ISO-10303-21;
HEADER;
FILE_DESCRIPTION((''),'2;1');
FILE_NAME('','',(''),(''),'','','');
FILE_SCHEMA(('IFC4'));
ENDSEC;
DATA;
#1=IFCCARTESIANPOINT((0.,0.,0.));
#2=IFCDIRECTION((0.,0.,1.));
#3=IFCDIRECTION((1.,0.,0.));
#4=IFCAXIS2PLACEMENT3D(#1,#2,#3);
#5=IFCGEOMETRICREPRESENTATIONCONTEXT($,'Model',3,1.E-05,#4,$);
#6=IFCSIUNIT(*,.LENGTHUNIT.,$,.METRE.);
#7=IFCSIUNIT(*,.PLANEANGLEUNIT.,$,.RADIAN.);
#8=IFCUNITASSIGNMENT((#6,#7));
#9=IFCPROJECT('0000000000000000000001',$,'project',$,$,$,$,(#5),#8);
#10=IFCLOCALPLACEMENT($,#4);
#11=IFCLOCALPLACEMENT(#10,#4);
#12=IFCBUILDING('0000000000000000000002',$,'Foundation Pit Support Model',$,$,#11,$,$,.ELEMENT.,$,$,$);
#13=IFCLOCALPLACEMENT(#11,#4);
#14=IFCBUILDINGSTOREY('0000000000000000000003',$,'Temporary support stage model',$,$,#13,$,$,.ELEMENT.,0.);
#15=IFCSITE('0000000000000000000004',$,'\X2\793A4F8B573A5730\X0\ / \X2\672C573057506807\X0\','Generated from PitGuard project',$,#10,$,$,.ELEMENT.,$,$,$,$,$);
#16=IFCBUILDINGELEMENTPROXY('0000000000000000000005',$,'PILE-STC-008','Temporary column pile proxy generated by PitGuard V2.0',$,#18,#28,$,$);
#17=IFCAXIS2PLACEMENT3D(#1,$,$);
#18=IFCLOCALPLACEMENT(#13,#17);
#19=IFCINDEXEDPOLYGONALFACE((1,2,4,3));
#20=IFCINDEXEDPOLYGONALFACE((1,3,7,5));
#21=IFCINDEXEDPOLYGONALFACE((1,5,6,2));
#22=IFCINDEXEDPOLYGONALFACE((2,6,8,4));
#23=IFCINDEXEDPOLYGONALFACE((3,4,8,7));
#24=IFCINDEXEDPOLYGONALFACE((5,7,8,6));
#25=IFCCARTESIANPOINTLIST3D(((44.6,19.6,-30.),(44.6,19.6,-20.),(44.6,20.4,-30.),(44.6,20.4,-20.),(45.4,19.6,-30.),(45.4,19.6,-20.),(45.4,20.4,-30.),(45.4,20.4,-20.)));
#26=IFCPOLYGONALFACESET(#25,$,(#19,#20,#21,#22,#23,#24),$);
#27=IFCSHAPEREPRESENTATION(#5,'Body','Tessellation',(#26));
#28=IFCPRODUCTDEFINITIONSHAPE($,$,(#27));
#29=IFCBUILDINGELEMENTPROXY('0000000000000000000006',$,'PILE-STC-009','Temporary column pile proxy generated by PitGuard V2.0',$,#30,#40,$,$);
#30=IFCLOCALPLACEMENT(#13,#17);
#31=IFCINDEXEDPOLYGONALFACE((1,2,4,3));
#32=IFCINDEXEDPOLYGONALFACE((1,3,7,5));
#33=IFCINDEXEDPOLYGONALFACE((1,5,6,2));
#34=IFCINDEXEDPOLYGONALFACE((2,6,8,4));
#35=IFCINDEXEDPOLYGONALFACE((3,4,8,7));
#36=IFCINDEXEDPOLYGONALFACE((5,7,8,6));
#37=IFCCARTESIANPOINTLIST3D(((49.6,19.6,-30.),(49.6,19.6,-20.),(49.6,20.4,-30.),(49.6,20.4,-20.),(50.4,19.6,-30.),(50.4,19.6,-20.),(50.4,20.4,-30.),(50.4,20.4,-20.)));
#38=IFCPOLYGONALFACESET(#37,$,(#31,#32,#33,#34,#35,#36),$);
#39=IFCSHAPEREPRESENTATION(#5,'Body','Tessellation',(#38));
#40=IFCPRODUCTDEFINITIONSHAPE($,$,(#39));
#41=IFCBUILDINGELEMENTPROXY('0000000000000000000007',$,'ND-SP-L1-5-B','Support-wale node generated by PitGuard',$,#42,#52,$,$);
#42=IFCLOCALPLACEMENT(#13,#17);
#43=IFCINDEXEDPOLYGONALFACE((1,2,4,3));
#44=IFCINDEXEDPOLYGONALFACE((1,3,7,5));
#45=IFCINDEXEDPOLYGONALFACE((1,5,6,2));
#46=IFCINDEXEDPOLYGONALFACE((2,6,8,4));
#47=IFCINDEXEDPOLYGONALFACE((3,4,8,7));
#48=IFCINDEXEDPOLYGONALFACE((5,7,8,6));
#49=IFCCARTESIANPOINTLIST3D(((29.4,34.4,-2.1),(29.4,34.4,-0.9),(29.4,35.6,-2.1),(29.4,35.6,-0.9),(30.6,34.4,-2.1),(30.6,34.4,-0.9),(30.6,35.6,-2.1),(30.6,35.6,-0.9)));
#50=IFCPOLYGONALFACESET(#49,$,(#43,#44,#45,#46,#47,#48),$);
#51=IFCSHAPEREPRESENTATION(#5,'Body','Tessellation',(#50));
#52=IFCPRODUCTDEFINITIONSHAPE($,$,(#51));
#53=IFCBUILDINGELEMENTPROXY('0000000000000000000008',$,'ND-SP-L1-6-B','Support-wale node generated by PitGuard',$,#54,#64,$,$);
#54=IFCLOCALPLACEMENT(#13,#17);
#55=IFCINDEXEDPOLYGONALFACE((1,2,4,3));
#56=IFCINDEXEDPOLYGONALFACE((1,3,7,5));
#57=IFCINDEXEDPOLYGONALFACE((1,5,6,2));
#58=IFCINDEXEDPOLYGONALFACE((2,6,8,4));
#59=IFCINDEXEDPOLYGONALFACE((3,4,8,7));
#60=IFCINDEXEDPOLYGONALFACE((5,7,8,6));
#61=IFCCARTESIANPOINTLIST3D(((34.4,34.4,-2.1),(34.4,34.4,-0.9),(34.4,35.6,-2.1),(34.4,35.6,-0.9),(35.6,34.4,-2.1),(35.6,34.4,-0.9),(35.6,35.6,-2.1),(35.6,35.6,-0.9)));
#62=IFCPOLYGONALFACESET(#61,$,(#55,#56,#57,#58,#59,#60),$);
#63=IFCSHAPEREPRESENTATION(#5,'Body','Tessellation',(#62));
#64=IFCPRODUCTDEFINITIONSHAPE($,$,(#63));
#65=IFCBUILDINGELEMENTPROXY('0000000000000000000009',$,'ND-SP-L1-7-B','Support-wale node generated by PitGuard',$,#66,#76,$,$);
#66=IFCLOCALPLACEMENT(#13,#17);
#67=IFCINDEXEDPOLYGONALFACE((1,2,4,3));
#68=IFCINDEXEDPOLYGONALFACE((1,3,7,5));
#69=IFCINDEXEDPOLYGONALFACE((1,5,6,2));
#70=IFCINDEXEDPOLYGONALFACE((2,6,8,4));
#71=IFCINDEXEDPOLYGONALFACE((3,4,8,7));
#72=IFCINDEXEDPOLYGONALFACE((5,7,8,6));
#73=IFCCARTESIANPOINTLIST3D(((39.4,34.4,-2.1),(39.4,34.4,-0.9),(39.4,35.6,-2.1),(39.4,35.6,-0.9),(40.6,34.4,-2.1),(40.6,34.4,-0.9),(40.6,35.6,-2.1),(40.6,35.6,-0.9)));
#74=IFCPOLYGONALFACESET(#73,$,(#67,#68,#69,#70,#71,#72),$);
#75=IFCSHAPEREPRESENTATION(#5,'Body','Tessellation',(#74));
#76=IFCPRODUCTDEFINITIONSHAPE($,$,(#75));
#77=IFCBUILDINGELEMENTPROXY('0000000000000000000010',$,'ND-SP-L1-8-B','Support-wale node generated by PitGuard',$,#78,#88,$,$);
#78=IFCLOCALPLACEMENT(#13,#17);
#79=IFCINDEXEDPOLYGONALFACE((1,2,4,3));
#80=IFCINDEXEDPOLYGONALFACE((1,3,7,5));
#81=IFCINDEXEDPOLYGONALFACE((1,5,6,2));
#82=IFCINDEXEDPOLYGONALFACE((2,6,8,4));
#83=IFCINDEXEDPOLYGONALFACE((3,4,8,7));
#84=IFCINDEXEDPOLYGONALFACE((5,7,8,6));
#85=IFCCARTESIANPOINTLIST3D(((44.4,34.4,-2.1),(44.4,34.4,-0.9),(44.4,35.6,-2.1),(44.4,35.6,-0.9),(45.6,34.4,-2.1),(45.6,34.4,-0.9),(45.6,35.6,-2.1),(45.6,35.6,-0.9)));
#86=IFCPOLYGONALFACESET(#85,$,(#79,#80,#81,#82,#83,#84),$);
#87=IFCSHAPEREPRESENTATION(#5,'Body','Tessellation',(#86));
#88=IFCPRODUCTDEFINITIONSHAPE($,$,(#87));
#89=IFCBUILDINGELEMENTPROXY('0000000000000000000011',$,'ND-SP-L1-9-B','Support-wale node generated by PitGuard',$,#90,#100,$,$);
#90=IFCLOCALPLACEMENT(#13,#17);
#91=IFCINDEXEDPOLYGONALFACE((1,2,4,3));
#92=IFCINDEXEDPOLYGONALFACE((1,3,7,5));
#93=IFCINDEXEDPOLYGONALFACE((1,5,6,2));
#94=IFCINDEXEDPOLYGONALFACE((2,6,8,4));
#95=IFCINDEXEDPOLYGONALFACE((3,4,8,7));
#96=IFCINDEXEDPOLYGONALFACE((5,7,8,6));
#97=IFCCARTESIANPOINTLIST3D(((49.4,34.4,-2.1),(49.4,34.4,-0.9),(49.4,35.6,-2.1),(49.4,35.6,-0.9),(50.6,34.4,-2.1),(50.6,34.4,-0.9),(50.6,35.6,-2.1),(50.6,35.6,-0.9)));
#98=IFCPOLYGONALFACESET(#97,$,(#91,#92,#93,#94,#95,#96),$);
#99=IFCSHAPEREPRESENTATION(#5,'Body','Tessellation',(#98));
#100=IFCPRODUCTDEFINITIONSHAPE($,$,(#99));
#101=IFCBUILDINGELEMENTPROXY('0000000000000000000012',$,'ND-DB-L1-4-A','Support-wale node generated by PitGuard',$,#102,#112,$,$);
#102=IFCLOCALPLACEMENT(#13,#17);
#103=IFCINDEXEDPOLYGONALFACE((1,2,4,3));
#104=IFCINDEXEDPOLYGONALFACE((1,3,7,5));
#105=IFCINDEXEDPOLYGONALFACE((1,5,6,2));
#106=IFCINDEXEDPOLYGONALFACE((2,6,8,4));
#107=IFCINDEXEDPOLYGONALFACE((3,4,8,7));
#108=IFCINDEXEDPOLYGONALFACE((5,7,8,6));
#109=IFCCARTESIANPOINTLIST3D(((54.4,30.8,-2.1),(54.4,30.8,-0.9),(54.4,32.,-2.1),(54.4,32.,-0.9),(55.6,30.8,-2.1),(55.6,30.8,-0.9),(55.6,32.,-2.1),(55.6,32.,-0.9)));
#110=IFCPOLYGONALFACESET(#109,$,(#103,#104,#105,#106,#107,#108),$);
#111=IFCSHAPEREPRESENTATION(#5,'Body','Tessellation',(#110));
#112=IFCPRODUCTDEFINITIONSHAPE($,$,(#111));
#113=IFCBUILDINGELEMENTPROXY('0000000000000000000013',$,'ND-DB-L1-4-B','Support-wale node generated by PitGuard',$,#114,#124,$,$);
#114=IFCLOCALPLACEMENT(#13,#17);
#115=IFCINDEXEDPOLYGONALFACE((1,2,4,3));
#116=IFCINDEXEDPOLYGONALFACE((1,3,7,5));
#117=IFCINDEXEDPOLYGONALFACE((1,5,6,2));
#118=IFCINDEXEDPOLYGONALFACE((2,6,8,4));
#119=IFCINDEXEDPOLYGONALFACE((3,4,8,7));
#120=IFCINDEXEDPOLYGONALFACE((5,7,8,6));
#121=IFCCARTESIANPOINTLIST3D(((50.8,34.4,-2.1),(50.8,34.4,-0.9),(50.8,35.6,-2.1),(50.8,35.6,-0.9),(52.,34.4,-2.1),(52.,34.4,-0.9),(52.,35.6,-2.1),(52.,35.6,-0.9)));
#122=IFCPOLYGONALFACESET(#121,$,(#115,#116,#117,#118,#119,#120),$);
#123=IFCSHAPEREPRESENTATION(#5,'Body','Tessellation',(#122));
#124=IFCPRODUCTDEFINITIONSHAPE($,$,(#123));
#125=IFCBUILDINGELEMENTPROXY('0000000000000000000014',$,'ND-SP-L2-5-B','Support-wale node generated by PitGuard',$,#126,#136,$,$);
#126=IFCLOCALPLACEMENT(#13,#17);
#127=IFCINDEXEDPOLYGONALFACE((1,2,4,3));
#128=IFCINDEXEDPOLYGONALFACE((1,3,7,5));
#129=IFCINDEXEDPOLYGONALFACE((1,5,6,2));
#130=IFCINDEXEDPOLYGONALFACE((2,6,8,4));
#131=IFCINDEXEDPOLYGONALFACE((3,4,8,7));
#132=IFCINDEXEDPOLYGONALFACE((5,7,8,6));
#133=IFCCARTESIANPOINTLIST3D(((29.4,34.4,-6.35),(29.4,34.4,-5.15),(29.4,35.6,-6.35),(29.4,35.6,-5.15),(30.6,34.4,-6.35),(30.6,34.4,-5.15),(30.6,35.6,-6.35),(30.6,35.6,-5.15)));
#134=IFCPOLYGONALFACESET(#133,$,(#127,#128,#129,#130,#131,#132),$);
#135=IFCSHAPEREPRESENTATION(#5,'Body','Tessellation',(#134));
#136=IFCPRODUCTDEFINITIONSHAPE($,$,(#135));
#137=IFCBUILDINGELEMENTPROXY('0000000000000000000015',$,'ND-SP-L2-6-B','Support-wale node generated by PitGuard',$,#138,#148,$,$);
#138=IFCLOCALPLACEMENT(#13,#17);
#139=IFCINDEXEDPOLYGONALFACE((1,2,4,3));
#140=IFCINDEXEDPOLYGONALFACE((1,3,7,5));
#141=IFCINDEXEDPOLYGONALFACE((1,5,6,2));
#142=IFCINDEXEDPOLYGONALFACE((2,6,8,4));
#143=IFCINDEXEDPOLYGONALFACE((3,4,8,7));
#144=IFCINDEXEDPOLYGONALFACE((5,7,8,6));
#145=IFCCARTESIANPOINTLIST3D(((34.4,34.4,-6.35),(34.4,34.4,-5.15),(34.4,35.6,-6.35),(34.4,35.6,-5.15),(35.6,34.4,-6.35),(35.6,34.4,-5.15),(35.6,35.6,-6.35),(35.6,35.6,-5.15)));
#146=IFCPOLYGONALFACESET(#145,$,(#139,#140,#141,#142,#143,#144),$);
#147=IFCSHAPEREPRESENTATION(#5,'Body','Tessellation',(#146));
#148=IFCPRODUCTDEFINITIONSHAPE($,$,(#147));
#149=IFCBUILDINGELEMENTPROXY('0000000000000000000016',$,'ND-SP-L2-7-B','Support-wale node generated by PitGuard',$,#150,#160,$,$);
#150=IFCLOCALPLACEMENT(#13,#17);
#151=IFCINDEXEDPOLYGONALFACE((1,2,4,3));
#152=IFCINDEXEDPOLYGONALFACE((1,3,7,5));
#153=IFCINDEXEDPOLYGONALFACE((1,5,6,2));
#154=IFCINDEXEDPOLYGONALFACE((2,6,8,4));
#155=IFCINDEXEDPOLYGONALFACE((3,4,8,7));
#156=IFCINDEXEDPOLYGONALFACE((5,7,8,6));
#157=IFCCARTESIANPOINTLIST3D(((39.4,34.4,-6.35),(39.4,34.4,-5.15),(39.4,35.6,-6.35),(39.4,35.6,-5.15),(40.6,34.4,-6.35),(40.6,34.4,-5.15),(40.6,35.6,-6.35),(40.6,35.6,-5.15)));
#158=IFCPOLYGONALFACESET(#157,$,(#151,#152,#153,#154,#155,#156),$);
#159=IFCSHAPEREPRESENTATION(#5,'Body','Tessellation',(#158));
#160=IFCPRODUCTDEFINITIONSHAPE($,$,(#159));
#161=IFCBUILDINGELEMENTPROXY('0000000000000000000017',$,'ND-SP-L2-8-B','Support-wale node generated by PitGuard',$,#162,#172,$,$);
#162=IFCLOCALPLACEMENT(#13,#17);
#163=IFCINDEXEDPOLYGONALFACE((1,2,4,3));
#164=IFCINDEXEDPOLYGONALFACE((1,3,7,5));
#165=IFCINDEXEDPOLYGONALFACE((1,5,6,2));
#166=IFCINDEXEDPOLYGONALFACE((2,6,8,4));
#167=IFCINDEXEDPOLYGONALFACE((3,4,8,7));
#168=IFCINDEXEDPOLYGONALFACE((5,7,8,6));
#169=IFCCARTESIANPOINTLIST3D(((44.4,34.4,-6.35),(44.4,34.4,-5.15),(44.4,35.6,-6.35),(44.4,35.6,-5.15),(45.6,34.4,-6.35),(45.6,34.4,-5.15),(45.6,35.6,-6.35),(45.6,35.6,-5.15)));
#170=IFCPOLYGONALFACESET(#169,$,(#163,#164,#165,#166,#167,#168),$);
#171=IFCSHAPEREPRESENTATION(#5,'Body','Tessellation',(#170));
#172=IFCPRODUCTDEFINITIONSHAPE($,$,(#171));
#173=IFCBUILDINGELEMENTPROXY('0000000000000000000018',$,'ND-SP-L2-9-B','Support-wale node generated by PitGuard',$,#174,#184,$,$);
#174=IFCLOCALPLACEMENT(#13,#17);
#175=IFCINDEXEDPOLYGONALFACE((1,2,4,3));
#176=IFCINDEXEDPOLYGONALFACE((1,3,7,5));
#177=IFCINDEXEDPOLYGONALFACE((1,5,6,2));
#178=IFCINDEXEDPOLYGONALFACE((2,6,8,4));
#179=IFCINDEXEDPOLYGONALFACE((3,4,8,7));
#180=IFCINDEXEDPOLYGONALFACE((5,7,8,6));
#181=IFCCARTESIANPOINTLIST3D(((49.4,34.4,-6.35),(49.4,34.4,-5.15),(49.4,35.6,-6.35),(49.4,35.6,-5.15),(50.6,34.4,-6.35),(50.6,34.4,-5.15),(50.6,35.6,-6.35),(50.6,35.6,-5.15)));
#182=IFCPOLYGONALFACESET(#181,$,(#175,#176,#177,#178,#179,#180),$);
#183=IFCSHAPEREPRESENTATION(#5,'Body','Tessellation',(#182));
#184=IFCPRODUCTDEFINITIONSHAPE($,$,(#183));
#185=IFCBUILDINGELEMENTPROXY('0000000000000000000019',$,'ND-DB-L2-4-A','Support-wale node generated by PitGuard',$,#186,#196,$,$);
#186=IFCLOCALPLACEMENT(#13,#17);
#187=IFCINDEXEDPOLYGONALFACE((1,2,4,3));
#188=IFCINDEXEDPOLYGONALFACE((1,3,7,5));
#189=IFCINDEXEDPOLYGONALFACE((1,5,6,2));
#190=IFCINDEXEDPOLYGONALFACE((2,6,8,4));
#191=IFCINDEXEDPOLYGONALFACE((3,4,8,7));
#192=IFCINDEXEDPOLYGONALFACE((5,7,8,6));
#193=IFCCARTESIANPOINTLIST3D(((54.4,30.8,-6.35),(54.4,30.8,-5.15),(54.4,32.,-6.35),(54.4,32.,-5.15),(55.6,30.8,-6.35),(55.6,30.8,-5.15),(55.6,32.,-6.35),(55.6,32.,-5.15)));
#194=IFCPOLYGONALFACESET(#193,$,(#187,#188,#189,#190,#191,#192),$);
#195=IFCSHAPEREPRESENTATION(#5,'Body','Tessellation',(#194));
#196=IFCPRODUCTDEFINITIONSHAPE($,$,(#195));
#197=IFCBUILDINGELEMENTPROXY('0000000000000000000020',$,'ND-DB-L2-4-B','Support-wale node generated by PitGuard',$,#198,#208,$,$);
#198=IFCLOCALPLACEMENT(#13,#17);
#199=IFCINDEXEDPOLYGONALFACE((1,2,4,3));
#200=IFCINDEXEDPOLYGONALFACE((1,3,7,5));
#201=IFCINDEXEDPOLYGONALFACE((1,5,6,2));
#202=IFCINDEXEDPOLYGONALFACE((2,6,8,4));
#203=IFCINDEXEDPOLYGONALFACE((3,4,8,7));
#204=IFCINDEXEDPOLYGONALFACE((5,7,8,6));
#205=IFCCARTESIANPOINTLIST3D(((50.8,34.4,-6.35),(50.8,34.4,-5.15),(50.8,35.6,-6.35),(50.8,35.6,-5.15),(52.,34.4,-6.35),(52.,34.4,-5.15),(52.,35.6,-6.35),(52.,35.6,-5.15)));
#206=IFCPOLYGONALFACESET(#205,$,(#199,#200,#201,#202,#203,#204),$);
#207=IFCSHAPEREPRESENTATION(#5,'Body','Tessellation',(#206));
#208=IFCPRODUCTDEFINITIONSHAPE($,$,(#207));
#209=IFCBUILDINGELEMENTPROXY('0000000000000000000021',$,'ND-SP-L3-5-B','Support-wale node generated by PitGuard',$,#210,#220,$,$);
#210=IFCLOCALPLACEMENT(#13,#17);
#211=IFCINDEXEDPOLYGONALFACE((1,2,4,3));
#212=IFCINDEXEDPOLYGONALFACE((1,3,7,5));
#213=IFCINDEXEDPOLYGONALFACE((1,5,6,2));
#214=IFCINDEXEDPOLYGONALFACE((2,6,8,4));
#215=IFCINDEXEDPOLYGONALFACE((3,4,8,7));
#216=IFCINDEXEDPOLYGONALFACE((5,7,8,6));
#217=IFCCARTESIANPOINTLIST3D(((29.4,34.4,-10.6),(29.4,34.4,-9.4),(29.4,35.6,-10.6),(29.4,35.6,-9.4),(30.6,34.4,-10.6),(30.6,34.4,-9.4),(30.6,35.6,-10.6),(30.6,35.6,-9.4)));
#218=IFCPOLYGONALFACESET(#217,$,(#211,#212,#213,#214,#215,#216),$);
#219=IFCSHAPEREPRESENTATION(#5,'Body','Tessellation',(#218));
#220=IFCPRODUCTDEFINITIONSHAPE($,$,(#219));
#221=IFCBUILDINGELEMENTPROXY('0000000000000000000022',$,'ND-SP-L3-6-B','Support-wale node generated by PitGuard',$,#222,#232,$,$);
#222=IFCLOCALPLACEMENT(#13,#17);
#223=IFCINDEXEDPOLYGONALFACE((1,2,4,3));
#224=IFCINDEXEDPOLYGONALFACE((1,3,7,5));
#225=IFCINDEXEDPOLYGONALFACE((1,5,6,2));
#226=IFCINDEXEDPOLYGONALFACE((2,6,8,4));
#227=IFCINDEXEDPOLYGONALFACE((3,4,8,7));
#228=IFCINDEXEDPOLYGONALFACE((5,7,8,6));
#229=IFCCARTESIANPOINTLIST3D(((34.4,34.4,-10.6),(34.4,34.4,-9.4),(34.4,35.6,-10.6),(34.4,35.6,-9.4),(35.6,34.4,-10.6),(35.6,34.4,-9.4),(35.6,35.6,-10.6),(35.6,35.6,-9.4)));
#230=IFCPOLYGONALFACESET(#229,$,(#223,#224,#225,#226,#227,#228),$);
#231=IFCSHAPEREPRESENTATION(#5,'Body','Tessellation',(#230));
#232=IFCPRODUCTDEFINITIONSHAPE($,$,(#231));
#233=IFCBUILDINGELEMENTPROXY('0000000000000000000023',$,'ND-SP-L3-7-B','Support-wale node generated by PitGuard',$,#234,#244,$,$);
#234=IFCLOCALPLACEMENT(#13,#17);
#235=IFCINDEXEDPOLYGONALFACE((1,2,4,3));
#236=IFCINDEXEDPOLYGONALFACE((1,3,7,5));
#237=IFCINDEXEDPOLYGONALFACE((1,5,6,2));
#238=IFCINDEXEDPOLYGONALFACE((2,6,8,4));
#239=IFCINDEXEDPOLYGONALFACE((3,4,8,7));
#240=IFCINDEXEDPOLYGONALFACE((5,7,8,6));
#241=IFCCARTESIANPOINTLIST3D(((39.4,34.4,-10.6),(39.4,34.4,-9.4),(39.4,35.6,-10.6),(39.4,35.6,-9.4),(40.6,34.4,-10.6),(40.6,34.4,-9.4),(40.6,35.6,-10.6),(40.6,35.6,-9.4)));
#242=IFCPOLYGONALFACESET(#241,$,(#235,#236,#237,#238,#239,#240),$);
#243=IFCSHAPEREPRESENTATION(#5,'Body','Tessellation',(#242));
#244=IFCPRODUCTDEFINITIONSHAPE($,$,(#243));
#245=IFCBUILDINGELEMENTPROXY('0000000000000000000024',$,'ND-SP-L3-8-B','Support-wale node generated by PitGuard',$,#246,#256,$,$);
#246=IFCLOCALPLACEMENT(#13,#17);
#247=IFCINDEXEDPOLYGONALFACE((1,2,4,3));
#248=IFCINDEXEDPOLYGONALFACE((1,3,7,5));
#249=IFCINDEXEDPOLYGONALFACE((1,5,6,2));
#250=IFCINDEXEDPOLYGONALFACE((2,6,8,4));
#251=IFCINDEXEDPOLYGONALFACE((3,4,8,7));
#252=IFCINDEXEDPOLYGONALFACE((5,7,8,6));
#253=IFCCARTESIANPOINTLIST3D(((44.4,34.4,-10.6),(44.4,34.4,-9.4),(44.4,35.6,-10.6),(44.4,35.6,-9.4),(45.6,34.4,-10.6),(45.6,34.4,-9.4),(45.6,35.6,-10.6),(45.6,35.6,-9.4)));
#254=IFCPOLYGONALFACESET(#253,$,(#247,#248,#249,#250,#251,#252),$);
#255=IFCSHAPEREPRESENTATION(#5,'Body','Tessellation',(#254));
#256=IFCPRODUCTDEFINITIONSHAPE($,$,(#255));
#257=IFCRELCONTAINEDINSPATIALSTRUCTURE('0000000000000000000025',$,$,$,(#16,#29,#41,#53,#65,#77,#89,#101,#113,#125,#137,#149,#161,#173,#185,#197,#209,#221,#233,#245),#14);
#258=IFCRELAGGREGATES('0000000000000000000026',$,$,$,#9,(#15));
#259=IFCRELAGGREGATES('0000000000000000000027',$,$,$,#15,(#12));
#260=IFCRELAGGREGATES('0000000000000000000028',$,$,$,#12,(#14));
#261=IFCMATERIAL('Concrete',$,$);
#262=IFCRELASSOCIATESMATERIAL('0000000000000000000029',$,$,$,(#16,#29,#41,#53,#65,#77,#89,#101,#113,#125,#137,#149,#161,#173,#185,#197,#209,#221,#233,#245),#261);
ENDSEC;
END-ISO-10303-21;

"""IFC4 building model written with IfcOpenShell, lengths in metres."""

from ifc_helpers import new_model, si_unit, frame, origin_with_axes, origin_2d, place, context, project, spatial, rectangle, extrude, material, element, save


model = new_model("IFC4")

# Units and contexts
model_context = context("Model", 3, precision=1e-05, world=origin_with_axes())
ifc_project = project(units=[si_unit("LENGTHUNIT", "METRE"), si_unit("PLANEANGLEUNIT", "RADIAN")], contexts=[model_context])

# Site, building, storey
site_placement = place(None, origin_with_axes())
site = spatial("IfcSite", under=ifc_project, at=site_placement, Name="示例场地 / 本地坐标", Description="Generated from PitGuard project", CompositionType="ELEMENT")
building_placement = place(site_placement, origin_with_axes())
building = spatial("IfcBuilding", under=site, at=building_placement, Name="Foundation Pit Support Model", CompositionType="ELEMENT")
storey_placement = place(building_placement, origin_with_axes())
storey = spatial("IfcBuildingStorey", under=building, at=storey_placement, Name="Temporary support stage model", CompositionType="ELEMENT", Elevation=0.0)

# Shared definitions
ifc_material_1 = material(Name="Concrete")

# Building element proxies
for number, where, z_axis, x_axis, name in (
    (1, (45.0, 20.0, -30.0), (0.0, 0.0, 1.0), (1.0, 0.0, 0.0), "PILE-STC-008"),
    (2, (50.0, 20.0, -30.0), (0.0, 0.0, 1.0), (1.0, 0.0, 0.0), "PILE-STC-009"),
):
    element("IfcBuildingElementProxy", number, at=place(storey_placement, frame(where, z_axis=z_axis, x_axis=x_axis)), inside=storey, material=ifc_material_1, Name=name, Description="Temporary column pile proxy generated by PitGuard V2.0", context=model_context, shape_type="SweptSolid", body=[
        extrude(rectangle(XDim=0.8, YDim=0.8, at=origin_2d()), origin_with_axes(), (0.0, 0.0, 1.0), 10.0),
    ])
for number, where, z_axis, x_axis, name in (
    (3, (30.0, 35.0, -2.1), (0.0, 0.0, 1.0), (1.0, 0.0, 0.0), "ND-SP-L1-5-B"),
    (4, (35.0, 35.0, -2.1), (0.0, 0.0, 1.0), (1.0, 0.0, 0.0), "ND-SP-L1-6-B"),
    (5, (40.0, 35.0, -2.1), (0.0, 0.0, 1.0), (1.0, 0.0, 0.0), "ND-SP-L1-7-B"),
    (6, (45.0, 35.0, -2.1), (0.0, 0.0, 1.0), (1.0, 0.0, 0.0), "ND-SP-L1-8-B"),
    (7, (50.0, 35.0, -2.1), (0.0, 0.0, 1.0), (1.0, 0.0, 0.0), "ND-SP-L1-9-B"),
    (8, (55.0, 31.4, -2.1), (0.0, 0.0, 1.0), (1.0, 0.0, 0.0), "ND-DB-L1-4-A"),
    (9, (51.4, 35.0, -2.1), (0.0, 0.0, 1.0), (1.0, 0.0, 0.0), "ND-DB-L1-4-B"),
    (10, (30.0, 35.0, -6.35), (0.0, 0.0, 1.0), (1.0, 0.0, 0.0), "ND-SP-L2-5-B"),
    (11, (35.0, 35.0, -6.35), (0.0, 0.0, 1.0), (1.0, 0.0, 0.0), "ND-SP-L2-6-B"),
    (12, (40.0, 35.0, -6.35), (0.0, 0.0, 1.0), (1.0, 0.0, 0.0), "ND-SP-L2-7-B"),
    (13, (45.0, 35.0, -6.35), (0.0, 0.0, 1.0), (1.0, 0.0, 0.0), "ND-SP-L2-8-B"),
    (14, (50.0, 35.0, -6.35), (0.0, 0.0, 1.0), (1.0, 0.0, 0.0), "ND-SP-L2-9-B"),
    (15, (55.0, 31.4, -6.35), (0.0, 0.0, 1.0), (1.0, 0.0, 0.0), "ND-DB-L2-4-A"),
    (16, (51.4, 35.0, -6.35), (0.0, 0.0, 1.0), (1.0, 0.0, 0.0), "ND-DB-L2-4-B"),
    (17, (30.0, 35.0, -10.6), (0.0, 0.0, 1.0), (1.0, 0.0, 0.0), "ND-SP-L3-5-B"),
    (18, (35.0, 35.0, -10.6), (0.0, 0.0, 1.0), (1.0, 0.0, 0.0), "ND-SP-L3-6-B"),
    (19, (40.0, 35.0, -10.6), (0.0, 0.0, 1.0), (1.0, 0.0, 0.0), "ND-SP-L3-7-B"),
    (20, (45.0, 35.0, -10.6), (0.0, 0.0, 1.0), (1.0, 0.0, 0.0), "ND-SP-L3-8-B"),
):
    element("IfcBuildingElementProxy", number, at=place(storey_placement, frame(where, z_axis=z_axis, x_axis=x_axis)), inside=storey, material=ifc_material_1, Name=name, Description="Support-wale node generated by PitGuard", context=model_context, shape_type="SweptSolid", body=[
        extrude(rectangle(XDim=1.2, YDim=1.2, at=origin_2d()), origin_with_axes(), (0.0, 0.0, 1.0), 1.2),
    ])

save(model, "model.ifc")
